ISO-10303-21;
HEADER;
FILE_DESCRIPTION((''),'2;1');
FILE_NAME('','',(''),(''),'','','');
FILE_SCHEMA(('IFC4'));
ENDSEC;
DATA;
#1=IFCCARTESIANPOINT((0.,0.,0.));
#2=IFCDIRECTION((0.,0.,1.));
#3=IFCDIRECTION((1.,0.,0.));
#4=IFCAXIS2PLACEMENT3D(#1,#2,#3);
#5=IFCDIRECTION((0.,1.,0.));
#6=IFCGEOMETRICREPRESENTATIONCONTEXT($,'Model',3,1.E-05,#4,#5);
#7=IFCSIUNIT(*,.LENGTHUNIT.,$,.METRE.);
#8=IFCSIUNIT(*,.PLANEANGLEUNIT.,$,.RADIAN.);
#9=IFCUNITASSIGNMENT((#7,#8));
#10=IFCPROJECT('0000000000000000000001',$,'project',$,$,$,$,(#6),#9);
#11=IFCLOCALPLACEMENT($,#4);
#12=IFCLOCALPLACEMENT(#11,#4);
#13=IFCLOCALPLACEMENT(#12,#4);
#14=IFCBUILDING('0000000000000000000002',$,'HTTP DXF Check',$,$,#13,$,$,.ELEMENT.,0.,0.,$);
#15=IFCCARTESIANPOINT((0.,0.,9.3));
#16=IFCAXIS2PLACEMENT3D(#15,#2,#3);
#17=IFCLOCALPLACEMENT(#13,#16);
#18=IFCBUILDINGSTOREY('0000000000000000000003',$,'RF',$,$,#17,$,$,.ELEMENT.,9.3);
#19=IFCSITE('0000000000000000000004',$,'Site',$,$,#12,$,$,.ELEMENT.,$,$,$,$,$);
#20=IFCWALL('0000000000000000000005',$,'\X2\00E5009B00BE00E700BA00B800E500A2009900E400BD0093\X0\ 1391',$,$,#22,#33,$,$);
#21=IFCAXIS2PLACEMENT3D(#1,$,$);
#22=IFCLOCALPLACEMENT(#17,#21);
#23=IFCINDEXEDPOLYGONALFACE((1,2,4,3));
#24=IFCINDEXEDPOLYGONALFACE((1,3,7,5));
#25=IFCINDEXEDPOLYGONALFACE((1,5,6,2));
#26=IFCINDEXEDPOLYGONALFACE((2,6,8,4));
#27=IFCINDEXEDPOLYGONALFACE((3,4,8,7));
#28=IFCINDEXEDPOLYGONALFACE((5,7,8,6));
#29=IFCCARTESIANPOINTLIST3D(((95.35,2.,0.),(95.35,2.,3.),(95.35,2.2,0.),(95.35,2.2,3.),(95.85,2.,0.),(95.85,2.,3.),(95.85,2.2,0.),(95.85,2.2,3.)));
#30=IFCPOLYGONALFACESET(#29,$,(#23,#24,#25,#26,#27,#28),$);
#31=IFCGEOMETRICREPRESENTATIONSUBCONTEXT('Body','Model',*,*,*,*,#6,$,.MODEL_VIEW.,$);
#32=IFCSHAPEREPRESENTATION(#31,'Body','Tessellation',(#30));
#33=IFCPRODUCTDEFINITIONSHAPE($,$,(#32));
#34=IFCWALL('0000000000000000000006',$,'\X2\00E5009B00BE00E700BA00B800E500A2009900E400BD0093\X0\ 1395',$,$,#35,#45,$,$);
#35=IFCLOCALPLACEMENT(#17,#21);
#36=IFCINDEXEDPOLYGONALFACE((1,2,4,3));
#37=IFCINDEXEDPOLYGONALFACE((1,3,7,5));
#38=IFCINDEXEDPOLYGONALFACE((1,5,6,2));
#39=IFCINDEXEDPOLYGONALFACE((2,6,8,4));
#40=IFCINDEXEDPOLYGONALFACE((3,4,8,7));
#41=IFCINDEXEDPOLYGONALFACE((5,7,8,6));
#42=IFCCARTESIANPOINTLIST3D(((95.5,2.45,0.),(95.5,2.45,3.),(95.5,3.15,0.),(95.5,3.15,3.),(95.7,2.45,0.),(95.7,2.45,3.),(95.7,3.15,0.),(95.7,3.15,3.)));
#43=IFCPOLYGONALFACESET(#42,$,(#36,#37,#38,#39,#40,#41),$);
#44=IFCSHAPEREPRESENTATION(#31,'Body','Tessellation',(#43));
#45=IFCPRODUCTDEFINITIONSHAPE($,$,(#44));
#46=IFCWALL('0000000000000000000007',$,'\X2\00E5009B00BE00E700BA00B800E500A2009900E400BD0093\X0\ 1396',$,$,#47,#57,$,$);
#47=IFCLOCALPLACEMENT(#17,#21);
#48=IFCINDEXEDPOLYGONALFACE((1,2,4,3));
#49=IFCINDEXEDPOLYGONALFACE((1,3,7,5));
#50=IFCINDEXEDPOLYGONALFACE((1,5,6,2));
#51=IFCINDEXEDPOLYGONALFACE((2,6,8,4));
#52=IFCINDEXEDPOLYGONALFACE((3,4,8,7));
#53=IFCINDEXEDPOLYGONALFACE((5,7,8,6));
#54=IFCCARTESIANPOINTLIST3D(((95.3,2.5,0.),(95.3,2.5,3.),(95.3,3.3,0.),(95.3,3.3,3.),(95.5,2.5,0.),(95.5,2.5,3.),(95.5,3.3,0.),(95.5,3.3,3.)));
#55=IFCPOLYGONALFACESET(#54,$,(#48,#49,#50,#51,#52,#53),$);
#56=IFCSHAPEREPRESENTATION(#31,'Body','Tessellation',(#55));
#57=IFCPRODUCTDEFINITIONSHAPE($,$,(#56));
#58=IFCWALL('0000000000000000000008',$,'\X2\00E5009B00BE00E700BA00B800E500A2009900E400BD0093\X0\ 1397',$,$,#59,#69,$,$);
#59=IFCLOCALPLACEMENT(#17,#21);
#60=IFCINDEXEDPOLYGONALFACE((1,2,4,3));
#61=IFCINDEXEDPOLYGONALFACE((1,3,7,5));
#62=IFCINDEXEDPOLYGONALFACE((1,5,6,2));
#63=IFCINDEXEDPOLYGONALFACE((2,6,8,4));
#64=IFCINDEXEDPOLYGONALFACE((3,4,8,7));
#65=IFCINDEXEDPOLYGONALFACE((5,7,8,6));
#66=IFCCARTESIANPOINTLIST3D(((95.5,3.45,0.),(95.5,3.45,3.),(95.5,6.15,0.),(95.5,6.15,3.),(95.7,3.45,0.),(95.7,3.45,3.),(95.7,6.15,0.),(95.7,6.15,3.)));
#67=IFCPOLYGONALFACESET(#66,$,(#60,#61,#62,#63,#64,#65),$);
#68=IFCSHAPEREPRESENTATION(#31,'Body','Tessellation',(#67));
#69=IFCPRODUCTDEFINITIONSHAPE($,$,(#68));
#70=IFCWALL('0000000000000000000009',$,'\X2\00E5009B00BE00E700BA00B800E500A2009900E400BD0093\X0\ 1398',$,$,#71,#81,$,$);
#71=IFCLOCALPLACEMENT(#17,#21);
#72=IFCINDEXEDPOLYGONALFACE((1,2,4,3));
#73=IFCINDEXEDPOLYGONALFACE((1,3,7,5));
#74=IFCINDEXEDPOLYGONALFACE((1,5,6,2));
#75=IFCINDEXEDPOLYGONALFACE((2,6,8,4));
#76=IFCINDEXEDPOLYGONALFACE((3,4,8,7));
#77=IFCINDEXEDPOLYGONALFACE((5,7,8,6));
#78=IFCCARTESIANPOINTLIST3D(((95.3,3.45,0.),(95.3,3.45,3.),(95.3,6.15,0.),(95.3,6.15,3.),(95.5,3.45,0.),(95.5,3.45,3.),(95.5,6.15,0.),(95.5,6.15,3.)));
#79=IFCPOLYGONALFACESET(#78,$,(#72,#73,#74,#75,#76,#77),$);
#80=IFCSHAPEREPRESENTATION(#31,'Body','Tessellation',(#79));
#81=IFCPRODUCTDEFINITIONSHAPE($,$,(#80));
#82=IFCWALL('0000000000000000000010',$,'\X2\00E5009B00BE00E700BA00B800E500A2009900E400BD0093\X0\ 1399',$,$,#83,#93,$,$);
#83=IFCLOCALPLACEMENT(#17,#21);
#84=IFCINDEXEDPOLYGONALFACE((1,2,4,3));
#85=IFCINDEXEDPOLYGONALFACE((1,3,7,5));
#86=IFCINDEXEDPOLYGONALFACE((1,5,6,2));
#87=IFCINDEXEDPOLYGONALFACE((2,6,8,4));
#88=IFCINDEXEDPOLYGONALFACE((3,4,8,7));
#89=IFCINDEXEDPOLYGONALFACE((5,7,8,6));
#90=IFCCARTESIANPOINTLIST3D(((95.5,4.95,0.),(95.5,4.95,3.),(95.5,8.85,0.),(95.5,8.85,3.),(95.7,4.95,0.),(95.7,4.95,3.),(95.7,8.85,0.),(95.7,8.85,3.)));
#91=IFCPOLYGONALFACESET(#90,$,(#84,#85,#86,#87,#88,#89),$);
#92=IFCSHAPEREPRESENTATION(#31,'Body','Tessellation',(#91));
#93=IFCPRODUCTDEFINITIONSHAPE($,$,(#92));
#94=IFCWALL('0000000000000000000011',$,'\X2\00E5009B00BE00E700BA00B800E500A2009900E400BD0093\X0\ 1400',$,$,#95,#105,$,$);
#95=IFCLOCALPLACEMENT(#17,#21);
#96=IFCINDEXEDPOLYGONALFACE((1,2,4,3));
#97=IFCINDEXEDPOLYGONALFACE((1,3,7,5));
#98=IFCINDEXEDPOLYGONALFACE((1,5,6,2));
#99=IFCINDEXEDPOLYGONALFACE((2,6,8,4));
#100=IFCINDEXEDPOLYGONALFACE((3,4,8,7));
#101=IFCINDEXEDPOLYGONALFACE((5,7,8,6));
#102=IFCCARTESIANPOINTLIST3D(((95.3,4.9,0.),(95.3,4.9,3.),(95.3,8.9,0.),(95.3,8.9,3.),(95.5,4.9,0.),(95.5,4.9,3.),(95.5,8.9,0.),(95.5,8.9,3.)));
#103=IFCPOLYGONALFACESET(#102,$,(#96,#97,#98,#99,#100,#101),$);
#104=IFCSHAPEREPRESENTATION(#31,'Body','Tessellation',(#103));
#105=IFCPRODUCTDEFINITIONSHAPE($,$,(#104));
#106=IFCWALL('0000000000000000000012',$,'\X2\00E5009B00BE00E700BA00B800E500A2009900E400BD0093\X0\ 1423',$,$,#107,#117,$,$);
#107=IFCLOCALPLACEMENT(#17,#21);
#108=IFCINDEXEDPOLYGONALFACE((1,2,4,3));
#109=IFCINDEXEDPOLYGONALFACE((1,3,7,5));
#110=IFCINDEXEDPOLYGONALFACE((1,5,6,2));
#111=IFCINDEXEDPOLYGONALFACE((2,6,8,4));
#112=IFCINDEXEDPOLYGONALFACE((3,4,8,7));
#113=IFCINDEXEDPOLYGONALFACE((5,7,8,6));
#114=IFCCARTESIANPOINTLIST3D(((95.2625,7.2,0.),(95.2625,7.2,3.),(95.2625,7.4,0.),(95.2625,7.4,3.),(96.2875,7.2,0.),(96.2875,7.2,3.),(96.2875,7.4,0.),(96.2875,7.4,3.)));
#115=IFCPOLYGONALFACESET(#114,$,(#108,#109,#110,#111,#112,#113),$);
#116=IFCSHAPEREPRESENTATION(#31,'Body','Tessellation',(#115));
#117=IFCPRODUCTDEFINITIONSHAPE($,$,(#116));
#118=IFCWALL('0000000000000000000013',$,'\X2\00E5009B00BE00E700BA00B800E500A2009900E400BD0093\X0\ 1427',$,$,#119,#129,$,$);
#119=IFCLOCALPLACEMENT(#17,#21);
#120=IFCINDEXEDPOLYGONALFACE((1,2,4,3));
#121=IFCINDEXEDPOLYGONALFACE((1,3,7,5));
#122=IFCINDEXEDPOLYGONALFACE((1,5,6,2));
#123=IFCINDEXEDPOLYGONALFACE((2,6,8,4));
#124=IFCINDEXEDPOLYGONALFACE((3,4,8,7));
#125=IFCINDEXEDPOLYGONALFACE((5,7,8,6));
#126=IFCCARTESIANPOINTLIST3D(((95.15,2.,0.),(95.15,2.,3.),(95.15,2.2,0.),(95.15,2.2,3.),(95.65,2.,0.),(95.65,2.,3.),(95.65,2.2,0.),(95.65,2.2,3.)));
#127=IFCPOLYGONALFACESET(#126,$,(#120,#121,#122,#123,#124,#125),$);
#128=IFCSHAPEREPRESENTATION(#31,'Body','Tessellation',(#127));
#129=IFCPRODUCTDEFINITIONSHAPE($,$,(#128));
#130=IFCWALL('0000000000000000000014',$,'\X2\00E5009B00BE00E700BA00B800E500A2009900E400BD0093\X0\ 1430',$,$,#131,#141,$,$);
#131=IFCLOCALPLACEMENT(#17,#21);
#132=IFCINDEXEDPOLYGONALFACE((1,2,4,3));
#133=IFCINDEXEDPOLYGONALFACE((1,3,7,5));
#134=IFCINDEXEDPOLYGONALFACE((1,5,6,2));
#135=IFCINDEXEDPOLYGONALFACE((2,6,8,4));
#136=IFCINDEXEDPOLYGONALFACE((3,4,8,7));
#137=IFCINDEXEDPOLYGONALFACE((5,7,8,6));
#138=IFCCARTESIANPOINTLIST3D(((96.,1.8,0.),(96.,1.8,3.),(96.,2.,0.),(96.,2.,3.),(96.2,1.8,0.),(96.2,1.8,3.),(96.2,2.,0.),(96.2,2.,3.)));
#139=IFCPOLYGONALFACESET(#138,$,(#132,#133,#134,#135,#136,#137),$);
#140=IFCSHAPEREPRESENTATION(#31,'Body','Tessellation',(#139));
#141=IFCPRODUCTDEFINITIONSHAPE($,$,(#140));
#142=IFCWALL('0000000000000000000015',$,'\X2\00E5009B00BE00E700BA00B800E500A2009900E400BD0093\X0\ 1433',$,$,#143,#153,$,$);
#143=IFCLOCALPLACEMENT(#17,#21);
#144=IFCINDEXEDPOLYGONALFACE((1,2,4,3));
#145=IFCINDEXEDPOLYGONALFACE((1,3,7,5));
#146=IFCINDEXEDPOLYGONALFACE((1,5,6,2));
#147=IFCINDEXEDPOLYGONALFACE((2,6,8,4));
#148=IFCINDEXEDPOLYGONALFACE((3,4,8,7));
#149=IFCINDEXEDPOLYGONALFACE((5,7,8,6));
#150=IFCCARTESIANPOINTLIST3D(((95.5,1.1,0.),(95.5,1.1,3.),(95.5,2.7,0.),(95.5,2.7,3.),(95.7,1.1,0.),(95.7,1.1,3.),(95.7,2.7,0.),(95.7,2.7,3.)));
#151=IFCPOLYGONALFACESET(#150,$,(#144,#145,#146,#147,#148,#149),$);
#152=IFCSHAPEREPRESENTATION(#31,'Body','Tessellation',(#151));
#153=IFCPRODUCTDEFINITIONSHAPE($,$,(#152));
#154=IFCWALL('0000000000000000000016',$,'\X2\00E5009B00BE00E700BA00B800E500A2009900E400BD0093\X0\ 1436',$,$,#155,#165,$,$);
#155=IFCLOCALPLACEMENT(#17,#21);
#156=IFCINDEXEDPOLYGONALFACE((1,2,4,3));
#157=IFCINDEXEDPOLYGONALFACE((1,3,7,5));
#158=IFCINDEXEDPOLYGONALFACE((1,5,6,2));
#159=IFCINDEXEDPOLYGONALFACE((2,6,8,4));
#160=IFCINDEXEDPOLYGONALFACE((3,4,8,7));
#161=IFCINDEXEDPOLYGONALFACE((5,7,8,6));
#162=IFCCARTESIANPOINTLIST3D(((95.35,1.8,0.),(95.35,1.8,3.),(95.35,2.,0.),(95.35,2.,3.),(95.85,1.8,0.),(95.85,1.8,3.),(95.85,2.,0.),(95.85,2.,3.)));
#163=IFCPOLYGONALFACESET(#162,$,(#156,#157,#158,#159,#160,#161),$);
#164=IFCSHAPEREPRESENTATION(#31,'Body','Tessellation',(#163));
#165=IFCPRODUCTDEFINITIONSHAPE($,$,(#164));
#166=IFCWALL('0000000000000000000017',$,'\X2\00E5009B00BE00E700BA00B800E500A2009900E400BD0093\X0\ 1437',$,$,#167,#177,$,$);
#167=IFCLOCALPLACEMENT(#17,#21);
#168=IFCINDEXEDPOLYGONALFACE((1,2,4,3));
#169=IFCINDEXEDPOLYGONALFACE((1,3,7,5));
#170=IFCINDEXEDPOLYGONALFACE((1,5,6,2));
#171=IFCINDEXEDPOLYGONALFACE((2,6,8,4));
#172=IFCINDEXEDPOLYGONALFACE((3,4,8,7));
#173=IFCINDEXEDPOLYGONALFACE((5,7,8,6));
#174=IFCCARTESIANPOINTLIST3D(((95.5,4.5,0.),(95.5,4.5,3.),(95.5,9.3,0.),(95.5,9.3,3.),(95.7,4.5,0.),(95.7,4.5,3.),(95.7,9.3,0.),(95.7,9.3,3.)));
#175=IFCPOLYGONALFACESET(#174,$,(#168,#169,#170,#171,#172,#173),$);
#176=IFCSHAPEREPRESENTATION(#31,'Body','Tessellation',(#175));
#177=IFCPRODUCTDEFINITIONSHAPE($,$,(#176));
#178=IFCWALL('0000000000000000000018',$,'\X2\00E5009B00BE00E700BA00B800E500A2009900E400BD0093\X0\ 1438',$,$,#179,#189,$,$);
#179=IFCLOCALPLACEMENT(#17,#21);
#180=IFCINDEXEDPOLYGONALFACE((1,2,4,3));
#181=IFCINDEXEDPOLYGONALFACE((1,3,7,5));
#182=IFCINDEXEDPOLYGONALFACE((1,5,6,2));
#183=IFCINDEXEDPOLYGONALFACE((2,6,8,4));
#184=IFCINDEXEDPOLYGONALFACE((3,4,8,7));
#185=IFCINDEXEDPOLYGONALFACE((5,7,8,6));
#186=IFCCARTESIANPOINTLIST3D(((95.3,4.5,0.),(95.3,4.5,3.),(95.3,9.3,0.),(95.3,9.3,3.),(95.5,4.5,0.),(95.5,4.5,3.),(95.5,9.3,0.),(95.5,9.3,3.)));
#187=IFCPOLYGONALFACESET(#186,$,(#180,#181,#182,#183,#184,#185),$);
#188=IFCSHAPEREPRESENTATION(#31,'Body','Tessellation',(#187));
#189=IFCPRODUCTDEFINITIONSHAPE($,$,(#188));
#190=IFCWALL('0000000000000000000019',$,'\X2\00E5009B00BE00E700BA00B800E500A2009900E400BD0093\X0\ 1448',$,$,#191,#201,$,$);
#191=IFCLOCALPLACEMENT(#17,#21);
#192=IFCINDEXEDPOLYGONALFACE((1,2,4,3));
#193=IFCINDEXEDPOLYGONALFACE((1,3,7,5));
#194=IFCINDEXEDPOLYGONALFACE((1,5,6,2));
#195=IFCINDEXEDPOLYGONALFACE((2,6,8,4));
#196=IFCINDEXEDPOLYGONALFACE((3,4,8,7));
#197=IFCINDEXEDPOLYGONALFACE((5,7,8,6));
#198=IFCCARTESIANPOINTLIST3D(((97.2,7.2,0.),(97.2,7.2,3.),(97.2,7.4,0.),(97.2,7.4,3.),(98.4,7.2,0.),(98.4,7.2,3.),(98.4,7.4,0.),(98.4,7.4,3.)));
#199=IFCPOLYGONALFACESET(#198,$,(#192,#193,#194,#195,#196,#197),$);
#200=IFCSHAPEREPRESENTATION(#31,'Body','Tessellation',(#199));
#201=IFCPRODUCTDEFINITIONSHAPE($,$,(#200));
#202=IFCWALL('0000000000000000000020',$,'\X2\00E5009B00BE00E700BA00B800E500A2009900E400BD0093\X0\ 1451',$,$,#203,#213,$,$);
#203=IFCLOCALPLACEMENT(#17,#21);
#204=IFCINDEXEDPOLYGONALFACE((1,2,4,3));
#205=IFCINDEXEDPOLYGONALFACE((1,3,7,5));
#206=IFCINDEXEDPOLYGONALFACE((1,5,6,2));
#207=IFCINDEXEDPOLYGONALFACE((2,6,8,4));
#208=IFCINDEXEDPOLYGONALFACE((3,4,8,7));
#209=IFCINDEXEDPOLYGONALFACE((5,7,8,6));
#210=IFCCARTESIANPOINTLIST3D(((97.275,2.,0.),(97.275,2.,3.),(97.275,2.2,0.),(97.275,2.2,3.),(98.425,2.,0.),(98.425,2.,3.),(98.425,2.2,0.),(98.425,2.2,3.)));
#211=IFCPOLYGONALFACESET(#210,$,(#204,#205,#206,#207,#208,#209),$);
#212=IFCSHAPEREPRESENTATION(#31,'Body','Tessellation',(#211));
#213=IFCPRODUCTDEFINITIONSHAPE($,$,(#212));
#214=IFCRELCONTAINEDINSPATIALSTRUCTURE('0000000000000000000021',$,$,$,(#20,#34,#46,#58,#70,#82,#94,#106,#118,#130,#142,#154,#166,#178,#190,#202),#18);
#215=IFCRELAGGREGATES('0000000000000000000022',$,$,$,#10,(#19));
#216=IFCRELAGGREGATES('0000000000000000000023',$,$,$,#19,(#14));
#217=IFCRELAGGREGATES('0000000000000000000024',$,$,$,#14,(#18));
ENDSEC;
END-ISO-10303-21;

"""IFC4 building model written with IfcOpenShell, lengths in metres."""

from ifc_helpers import new_model, si_unit, direction, frame, frame_2d, origin_with_axes, place, context, subcontext, project, spatial, rectangle, extrude, element, save


model = new_model("IFC4")

# Units and contexts
model_context = context("Model", 3, precision=1e-05, world=origin_with_axes(), true_north=direction((0.0, 1.0, 0.0)))
body_context = subcontext(model_context, "Body", "Model", "MODEL_VIEW")
ifc_project = project(units=[si_unit("LENGTHUNIT", "METRE"), si_unit("PLANEANGLEUNIT", "RADIAN")], contexts=[model_context])

# Site, building, storey
placement = place(None, origin_with_axes())
site_placement = place(placement, origin_with_axes())
site = spatial("IfcSite", under=ifc_project, at=site_placement, Name="Site", CompositionType="ELEMENT")
building_placement = place(site_placement, origin_with_axes())
building = spatial("IfcBuilding", under=site, at=building_placement, Name="HTTP DXF Check", CompositionType="ELEMENT", ElevationOfRefHeight=0.0, ElevationOfTerrain=0.0)
storey_placement = place(building_placement, frame((0.0, 0.0, 9.3), z_axis=(0.0, 0.0, 1.0), x_axis=(1.0, 0.0, 0.0)))
storey = spatial("IfcBuildingStorey", under=building, at=storey_placement, Name="RF", CompositionType="ELEMENT", Elevation=9.3)

# Walls
wall_1_placement = place(storey_placement, frame((95.6, 2.1, 0.0), z_axis=(0.0, 0.0, 1.0), x_axis=(1.0, 0.0, 0.0)))
element("IfcWall", 1, at=wall_1_placement, inside=storey, Name="å\u009b¾çº¸å¢\u0099ä½\u0093 1391", context=body_context, shape_type="SweptSolid", body=[
    extrude(rectangle(XDim=0.5, YDim=0.2, at=frame_2d((0.0, 0.0), x_axis=(1.0, 0.0, 0.0))), frame((0.0, 0.0, 0.0), z_axis=(0.0, 0.0, 1.0)), (0.0, 0.0, 1.0), 3.0),
])
wall_2_placement = place(storey_placement, frame((95.6, 2.8, 0.0), z_axis=(0.0, 0.0, 1.0), x_axis=(0.0, -1.0, 0.0)))
element("IfcWall", 2, at=wall_2_placement, inside=storey, Name="å\u009b¾çº¸å¢\u0099ä½\u0093 1395", context=body_context, shape_type="SweptSolid", body=[
    extrude(rectangle(XDim=0.7, YDim=0.2, at=frame_2d((0.0, 0.0), x_axis=(1.0, 0.0, 0.0))), frame((0.0, 0.0, 0.0), z_axis=(0.0, 0.0, 1.0)), (0.0, 0.0, 1.0), 3.0),
])
wall_3_placement = place(storey_placement, frame((95.4, 2.9, 0.0), z_axis=(0.0, 0.0, 1.0), x_axis=(0.0, -1.0, 0.0)))
element("IfcWall", 3, at=wall_3_placement, inside=storey, Name="å\u009b¾çº¸å¢\u0099ä½\u0093 1396", context=body_context, shape_type="SweptSolid", body=[
    extrude(rectangle(XDim=0.8, YDim=0.2, at=frame_2d((0.0, 0.0), x_axis=(1.0, 0.0, 0.0))), frame((0.0, 0.0, 0.0), z_axis=(0.0, 0.0, 1.0)), (0.0, 0.0, 1.0), 3.0),
])
for number, where, z_axis, x_axis, name in (
    (4, (95.6, 4.8, 0.0), (0.0, 0.0, 1.0), (0.0, -1.0, 0.0), "å\u009b¾çº¸å¢\u0099ä½\u0093 1397"),
    (5, (95.4, 4.8, 0.0), (0.0, 0.0, 1.0), (0.0, -1.0, 0.0), "å\u009b¾çº¸å¢\u0099ä½\u0093 1398"),
):
    element("IfcWall", number, at=place(storey_placement, frame(where, z_axis=z_axis, x_axis=x_axis)), inside=storey, Name=name, context=body_context, shape_type="SweptSolid", body=[
        extrude(rectangle(XDim=2.7, YDim=0.2, at=frame_2d((0.0, 0.0), x_axis=(1.0, 0.0, 0.0))), frame((0.0, 0.0, 0.0), z_axis=(0.0, 0.0, 1.0)), (0.0, 0.0, 1.0), 3.0),
    ])
wall_4_placement = place(storey_placement, frame((95.6, 6.9, 0.0), z_axis=(0.0, 0.0, 1.0), x_axis=(0.0, -1.0, 0.0)))
element("IfcWall", 6, at=wall_4_placement, inside=storey, Name="å\u009b¾çº¸å¢\u0099ä½\u0093 1399", context=body_context, shape_type="SweptSolid", body=[
    extrude(rectangle(XDim=3.9, YDim=0.2, at=frame_2d((0.0, 0.0), x_axis=(1.0, 0.0, 0.0))), frame((0.0, 0.0, 0.0), z_axis=(0.0, 0.0, 1.0)), (0.0, 0.0, 1.0), 3.0),
])
wall_5_placement = place(storey_placement, frame((95.4, 6.9, 0.0), z_axis=(0.0, 0.0, 1.0), x_axis=(0.0, -1.0, 0.0)))
element("IfcWall", 7, at=wall_5_placement, inside=storey, Name="å\u009b¾çº¸å¢\u0099ä½\u0093 1400", context=body_context, shape_type="SweptSolid", body=[
    extrude(rectangle(XDim=4.0, YDim=0.2, at=frame_2d((0.0, 0.0), x_axis=(1.0, 0.0, 0.0))), frame((0.0, 0.0, 0.0), z_axis=(0.0, 0.0, 1.0)), (0.0, 0.0, 1.0), 3.0),
])
wall_6_placement = place(storey_placement, frame((95.775, 7.3, 0.0), z_axis=(0.0, 0.0, 1.0), x_axis=(1.0, 0.0, 0.0)))
element("IfcWall", 8, at=wall_6_placement, inside=storey, Name="å\u009b¾çº¸å¢\u0099ä½\u0093 1423", context=body_context, shape_type="SweptSolid", body=[
    extrude(rectangle(XDim=1.025, YDim=0.2, at=frame_2d((0.0, 0.0), x_axis=(1.0, 0.0, 0.0))), frame((0.0, 0.0, 0.0), z_axis=(0.0, 0.0, 1.0)), (0.0, 0.0, 1.0), 3.0),
])
wall_7_placement = place(storey_placement, frame((95.4, 2.1, 0.0), z_axis=(0.0, 0.0, 1.0), x_axis=(-1.0, 0.0, 0.0)))
element("IfcWall", 9, at=wall_7_placement, inside=storey, Name="å\u009b¾çº¸å¢\u0099ä½\u0093 1427", context=body_context, shape_type="SweptSolid", body=[
    extrude(rectangle(XDim=0.5, YDim=0.2, at=frame_2d((0.0, 0.0), x_axis=(1.0, 0.0, 0.0))), frame((0.0, 0.0, 0.0), z_axis=(0.0, 0.0, 1.0)), (0.0, 0.0, 1.0), 3.0),
])
wall_8_placement = place(storey_placement, frame((96.1, 1.9, 0.0), z_axis=(0.0, 0.0, 1.0), x_axis=(0.0, 1.0, 0.0)))
element("IfcWall", 10, at=wall_8_placement, inside=storey, Name="å\u009b¾çº¸å¢\u0099ä½\u0093 1430", context=body_context, shape_type="SweptSolid", body=[
    extrude(rectangle(XDim=0.2, YDim=0.2, at=frame_2d((0.0, 0.0), x_axis=(1.0, 0.0, 0.0))), frame((0.0, 0.0, 0.0), z_axis=(0.0, 0.0, 1.0)), (0.0, 0.0, 1.0), 3.0),
])
wall_9_placement = place(storey_placement, frame((95.6, 1.9, 0.0), z_axis=(0.0, 0.0, 1.0), x_axis=(0.0, -1.0, 0.0)))
element("IfcWall", 11, at=wall_9_placement, inside=storey, Name="å\u009b¾çº¸å¢\u0099ä½\u0093 1433", context=body_context, shape_type="SweptSolid", body=[
    extrude(rectangle(XDim=1.6, YDim=0.2, at=frame_2d((0.0, 0.0), x_axis=(1.0, 0.0, 0.0))), frame((0.0, 0.0, 0.0), z_axis=(0.0, 0.0, 1.0)), (0.0, 0.0, 1.0), 3.0),
])
for number, where, z_axis, x_axis, name in (
    (12, (95.6, 1.9, 0.0), (0.0, 0.0, 1.0), (1.0, 0.0, 0.0), "å\u009b¾çº¸å¢\u0099ä½\u0093 1436"),
):
    element("IfcWall", number, at=place(storey_placement, frame(where, z_axis=z_axis, x_axis=x_axis)), inside=storey, Name=name, context=body_context, shape_type="SweptSolid", body=[
        extrude(rectangle(XDim=0.5, YDim=0.2, at=frame_2d((0.0, 0.0), x_axis=(1.0, 0.0, 0.0))), frame((0.0, 0.0, 0.0), z_axis=(0.0, 0.0, 1.0)), (0.0, 0.0, 1.0), 3.0),
    ])
for number, where, z_axis, x_axis, name in (
    (13, (95.6, 6.9, 0.0), (0.0, 0.0, 1.0), (0.0, -1.0, 0.0), "å\u009b¾çº¸å¢\u0099ä½\u0093 1437"),
    (14, (95.4, 6.9, 0.0), (0.0, 0.0, 1.0), (0.0, -1.0, 0.0), "å\u009b¾çº¸å¢\u0099ä½\u0093 1438"),
):
    element("IfcWall", number, at=place(storey_placement, frame(where, z_axis=z_axis, x_axis=x_axis)), inside=storey, Name=name, context=body_context, shape_type="SweptSolid", body=[
        extrude(rectangle(XDim=4.8, YDim=0.2, at=frame_2d((0.0, 0.0), x_axis=(1.0, 0.0, 0.0))), frame((0.0, 0.0, 0.0), z_axis=(0.0, 0.0, 1.0)), (0.0, 0.0, 1.0), 3.0),
    ])
wall_10_placement = place(storey_placement, frame((97.8, 7.3, 0.0), z_axis=(0.0, 0.0, 1.0), x_axis=(1.0, 0.0, 0.0)))
element("IfcWall", 15, at=wall_10_placement, inside=storey, Name="å\u009b¾çº¸å¢\u0099ä½\u0093 1448", context=body_context, shape_type="SweptSolid", body=[
    extrude(rectangle(XDim=1.2, YDim=0.2, at=frame_2d((0.0, 0.0), x_axis=(1.0, 0.0, 0.0))), frame((0.0, 0.0, 0.0), z_axis=(0.0, 0.0, 1.0)), (0.0, 0.0, 1.0), 3.0),
])
wall_11_placement = place(storey_placement, frame((97.85, 2.1, 0.0), z_axis=(0.0, 0.0, 1.0), x_axis=(1.0, 0.0, 0.0)))
element("IfcWall", 16, at=wall_11_placement, inside=storey, Name="å\u009b¾çº¸å¢\u0099ä½\u0093 1451", context=body_context, shape_type="SweptSolid", body=[
    extrude(rectangle(XDim=1.15, YDim=0.2, at=frame_2d((0.0, 0.0), x_axis=(1.0, 0.0, 0.0))), frame((0.0, 0.0, 0.0), z_axis=(0.0, 0.0, 1.0)), (0.0, 0.0, 1.0), 3.0),
])

save(model, "model.ifc")
